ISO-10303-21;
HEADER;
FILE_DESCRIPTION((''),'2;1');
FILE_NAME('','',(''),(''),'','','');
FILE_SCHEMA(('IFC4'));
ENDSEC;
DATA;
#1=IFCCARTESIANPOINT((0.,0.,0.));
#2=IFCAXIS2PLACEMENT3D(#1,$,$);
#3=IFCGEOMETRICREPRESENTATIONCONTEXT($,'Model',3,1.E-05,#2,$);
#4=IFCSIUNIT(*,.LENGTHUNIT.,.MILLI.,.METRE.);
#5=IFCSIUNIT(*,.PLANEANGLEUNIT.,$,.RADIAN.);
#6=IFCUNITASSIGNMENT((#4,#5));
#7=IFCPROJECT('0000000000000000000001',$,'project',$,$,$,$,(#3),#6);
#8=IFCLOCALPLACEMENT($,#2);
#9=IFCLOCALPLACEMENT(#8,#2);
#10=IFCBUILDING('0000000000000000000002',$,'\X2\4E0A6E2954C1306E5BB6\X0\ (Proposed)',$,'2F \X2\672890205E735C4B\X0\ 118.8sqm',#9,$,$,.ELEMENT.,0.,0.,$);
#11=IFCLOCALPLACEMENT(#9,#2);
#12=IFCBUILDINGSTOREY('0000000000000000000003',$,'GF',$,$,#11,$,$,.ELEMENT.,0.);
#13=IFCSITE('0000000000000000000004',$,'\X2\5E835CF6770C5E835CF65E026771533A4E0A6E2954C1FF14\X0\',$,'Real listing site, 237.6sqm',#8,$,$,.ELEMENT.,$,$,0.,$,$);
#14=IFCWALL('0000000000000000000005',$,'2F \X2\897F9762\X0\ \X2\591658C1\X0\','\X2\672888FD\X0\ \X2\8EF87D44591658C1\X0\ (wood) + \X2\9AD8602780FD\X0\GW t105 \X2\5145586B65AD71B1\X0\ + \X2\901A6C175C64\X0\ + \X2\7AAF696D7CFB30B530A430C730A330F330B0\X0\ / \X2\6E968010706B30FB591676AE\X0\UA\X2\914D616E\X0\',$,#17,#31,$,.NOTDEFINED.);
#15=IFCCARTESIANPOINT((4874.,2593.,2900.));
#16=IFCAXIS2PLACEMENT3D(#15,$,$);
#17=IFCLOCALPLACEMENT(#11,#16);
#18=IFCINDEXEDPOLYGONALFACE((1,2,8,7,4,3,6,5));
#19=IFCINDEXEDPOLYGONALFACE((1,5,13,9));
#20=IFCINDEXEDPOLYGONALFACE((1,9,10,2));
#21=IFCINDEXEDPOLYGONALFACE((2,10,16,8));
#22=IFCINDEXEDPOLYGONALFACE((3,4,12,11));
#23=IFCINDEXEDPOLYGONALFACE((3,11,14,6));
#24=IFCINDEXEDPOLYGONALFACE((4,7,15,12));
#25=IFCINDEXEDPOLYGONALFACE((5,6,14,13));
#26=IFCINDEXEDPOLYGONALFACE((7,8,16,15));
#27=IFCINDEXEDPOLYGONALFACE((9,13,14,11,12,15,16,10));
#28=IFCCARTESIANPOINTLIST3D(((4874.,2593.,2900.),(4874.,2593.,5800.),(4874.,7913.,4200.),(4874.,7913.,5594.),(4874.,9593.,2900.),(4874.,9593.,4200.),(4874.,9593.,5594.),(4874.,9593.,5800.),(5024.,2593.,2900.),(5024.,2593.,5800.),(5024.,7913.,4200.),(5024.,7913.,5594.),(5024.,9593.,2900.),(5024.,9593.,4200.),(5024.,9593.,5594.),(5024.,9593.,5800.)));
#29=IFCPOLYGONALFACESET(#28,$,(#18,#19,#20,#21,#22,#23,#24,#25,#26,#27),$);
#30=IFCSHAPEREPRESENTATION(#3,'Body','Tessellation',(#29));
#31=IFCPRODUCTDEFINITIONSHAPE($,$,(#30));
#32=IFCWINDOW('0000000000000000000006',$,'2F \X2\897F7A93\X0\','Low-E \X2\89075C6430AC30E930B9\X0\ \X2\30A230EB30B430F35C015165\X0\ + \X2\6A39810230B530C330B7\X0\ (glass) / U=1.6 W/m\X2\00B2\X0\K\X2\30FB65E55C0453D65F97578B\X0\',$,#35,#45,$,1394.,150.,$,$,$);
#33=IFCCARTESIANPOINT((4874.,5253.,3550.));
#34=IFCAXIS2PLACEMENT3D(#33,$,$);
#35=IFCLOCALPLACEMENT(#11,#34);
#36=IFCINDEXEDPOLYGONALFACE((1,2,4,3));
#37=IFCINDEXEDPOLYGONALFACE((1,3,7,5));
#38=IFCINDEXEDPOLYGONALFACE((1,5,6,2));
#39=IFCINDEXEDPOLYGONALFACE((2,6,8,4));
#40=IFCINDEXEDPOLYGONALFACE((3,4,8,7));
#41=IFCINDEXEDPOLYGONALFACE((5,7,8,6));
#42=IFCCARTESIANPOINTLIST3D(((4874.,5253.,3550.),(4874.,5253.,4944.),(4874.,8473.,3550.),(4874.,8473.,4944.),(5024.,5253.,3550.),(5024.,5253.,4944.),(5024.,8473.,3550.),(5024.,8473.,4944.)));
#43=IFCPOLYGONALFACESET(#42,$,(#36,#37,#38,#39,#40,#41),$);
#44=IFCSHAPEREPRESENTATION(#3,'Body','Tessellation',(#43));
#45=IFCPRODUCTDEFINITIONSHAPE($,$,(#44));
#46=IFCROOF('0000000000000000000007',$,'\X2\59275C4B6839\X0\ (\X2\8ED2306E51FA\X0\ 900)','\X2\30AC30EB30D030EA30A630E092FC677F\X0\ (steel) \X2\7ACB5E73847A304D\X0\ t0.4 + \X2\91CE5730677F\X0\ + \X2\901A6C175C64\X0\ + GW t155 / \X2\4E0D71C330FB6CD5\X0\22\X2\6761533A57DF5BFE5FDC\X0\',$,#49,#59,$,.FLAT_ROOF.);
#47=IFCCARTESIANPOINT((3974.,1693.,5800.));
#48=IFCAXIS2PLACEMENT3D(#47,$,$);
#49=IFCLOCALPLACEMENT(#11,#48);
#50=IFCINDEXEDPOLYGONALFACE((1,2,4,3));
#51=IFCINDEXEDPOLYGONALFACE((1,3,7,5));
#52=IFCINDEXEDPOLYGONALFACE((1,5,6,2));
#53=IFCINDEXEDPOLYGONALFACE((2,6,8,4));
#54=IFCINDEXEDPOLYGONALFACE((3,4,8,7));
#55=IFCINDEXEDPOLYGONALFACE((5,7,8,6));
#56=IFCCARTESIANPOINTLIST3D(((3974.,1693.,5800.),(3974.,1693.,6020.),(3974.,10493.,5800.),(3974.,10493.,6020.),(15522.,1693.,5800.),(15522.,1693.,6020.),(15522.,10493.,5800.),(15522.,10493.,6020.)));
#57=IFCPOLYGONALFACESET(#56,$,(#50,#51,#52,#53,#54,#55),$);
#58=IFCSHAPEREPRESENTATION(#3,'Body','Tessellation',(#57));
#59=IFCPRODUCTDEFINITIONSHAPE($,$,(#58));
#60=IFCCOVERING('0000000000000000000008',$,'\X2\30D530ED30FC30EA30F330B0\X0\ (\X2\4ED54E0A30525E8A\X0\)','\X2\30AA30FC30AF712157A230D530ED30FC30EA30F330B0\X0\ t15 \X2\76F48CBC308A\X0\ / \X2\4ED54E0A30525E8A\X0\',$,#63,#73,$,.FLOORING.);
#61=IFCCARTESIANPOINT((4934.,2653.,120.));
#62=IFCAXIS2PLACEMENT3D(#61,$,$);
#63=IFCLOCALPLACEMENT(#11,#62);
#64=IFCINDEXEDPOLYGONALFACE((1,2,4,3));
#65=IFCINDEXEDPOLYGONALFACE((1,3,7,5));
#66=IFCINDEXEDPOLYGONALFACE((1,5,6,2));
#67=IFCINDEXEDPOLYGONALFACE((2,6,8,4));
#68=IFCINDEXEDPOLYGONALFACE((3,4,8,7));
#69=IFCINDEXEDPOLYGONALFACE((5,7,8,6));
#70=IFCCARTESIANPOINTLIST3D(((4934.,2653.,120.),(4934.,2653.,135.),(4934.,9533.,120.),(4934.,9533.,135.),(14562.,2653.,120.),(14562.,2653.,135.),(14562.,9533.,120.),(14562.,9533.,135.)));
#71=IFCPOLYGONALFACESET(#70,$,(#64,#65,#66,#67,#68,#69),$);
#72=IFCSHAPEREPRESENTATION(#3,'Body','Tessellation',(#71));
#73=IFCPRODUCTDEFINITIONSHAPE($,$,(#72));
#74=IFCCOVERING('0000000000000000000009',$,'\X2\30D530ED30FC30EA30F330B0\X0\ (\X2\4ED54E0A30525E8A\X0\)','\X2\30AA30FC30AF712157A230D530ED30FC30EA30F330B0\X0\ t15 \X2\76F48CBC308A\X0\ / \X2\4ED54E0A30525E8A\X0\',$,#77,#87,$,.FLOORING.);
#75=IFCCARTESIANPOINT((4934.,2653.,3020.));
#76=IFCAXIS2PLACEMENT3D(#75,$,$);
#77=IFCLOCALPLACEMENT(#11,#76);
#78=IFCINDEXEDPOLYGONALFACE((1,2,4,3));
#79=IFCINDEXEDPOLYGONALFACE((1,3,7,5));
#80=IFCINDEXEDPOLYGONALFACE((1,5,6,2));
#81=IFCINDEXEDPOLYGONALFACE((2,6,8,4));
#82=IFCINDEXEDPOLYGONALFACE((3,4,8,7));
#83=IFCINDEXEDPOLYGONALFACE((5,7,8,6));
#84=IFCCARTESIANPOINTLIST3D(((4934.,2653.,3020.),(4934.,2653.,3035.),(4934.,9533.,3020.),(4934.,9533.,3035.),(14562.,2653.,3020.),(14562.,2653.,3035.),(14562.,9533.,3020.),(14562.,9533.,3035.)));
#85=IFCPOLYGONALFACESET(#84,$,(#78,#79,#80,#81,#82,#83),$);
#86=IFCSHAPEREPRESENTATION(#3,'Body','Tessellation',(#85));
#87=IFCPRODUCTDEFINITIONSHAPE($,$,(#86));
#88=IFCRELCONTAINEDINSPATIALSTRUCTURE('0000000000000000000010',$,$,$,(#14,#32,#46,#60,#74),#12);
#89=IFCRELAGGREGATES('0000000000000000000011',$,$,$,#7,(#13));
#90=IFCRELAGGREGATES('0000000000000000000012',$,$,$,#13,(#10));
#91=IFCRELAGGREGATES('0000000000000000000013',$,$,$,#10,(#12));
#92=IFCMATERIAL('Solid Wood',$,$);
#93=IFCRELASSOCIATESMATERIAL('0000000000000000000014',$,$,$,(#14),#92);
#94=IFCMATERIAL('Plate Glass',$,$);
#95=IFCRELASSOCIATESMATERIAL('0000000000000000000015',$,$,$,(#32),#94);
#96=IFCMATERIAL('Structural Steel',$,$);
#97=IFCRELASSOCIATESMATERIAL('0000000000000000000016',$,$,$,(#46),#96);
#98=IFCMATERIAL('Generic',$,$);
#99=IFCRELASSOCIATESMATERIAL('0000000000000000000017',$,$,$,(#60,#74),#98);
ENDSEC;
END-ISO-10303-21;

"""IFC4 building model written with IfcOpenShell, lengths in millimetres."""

from ifc_helpers import new_model, si_unit, frame, frame_2d, origin, place, context, project, spatial, rectangle, extrude, material, element, fill, save


model = new_model("IFC4")

# Units and contexts
model_context = context("Model", 3, precision=1e-05, world=origin())
ifc_project = project(units=[si_unit("LENGTHUNIT", "METRE", prefix="MILLI"), si_unit("PLANEANGLEUNIT", "RADIAN")], contexts=[model_context])

# Site, building, storey
site_placement = place(None, origin())
site = spatial("IfcSite", under=ifc_project, at=site_placement, Name="広島県広島市東区上温品４", ObjectType="Real listing site, 237.6sqm", CompositionType="ELEMENT", RefElevation=0.0)
building_placement = place(site_placement, origin())
building = spatial("IfcBuilding", under=site, at=building_placement, Name="上温品の家 (Proposed)", ObjectType="2F 木造平屋 118.8sqm", CompositionType="ELEMENT", ElevationOfRefHeight=0.0, ElevationOfTerrain=0.0)
storey_placement = place(building_placement, origin())
storey = spatial("IfcBuildingStorey", under=building, at=storey_placement, Name="GF", CompositionType="ELEMENT", Elevation=0.0)

# Shared definitions
ifc_material_1 = material(Name="Solid Wood")

# Shared definitions
ifc_material_2 = material(Name="Plate Glass")

# Wall, opening, window
wall_1_placement = place(storey_placement, frame((4874.0, 2593.0, 2900.0)))
wall_1 = element("IfcWall", 1, at=wall_1_placement, inside=storey, material=ifc_material_1, Name="2F 西面 外壁", Description="木製 軸組外壁 (wood) + 高性能GW t105 充填断熱 + 通気層 + 窯業系サイディング / 準耐火・外皮UA配慮", PredefinedType="NOTDEFINED", context=model_context, shape_type="SweptSolid", body=[
    extrude(rectangle(XDim=150.0, YDim=7000.0, at=frame_2d((75.0, 3500.0))), frame((4874.0, 2593.0, 2900.0)), (0.0, 0.0, 1.0), 2900.0),
])
opening_1_placement = place(storey_placement, frame((4874.0, 5253.0, 3550.0)))
opening_1 = element("IfcOpeningElement", 2, at=opening_1_placement, cuts=wall_1, PredefinedType="NOTDEFINED", context=model_context, shape_type="SweptSolid", body=[
    extrude(rectangle(XDim=150.0, YDim=3220.0, at=frame_2d((75.0, 1610.0))), frame((4874.0, 5253.0, 3550.0)), (0.0, 0.0, 1.0), 1394.0),
])
window_1_placement = place(storey_placement, frame((4874.0, 5253.0, 3550.0)))
window_1 = element("IfcWindow", 3, at=window_1_placement, inside=storey, material=ifc_material_2, Name="2F 西窓", Description="Low-E 複層ガラス アルゴン封入 + 樹脂サッシ (glass) / U=1.6 W/m²K・日射取得型", OverallHeight=1394.0, OverallWidth=150.0, context=model_context, shape_type="SweptSolid", body=[
    extrude(rectangle(XDim=150.0, YDim=3220.0, at=frame_2d((75.0, 1610.0))), frame((4874.0, 5253.0, 3550.0)), (0.0, 0.0, 1.0), 1394.0),
])
fill(opening_1, window_1)

# Roof
ifc_material_3 = material(Name="Structural Steel")
roof_placement = place(storey_placement, frame((3974.0, 1693.0, 5800.0)))
element("IfcRoof", 4, at=roof_placement, inside=storey, material=ifc_material_3, Name="大屋根 (軒の出 900)", Description="ガルバリウム鋼板 (steel) 立平葺き t0.4 + 野地板 + 通気層 + GW t155 / 不燃・法22条区域対応", PredefinedType="FLAT_ROOF", context=model_context, shape_type="SweptSolid", body=[
    extrude(rectangle(XDim=11548.0, YDim=8800.0, at=frame_2d((5774.0, 4400.0))), frame((3974.0, 1693.0, 5800.0)), (0.0, 0.0, 1.0), 220.0),
])

# Coverings
ifc_material_4 = material(Name="Generic")
covering_1_placement = place(storey_placement, frame((4934.0, 2653.0, 120.0)))
element("IfcCovering", 5, at=covering_1_placement, inside=storey, material=ifc_material_4, Name="フローリング (仕上げ床)", Description="オーク無垢フローリング t15 直貼り / 仕上げ床", PredefinedType="FLOORING", context=model_context, shape_type="SweptSolid", body=[
    extrude(rectangle(XDim=9628.0, YDim=6880.0, at=frame_2d((4814.0, 3440.0))), frame((4934.0, 2653.0, 120.0)), (0.0, 0.0, 1.0), 15.0),
])
covering_2_placement = place(storey_placement, frame((4934.0, 2653.0, 3020.0)))
element("IfcCovering", 6, at=covering_2_placement, inside=storey, material=ifc_material_4, Name="フローリング (仕上げ床)", Description="オーク無垢フローリング t15 直貼り / 仕上げ床", PredefinedType="FLOORING", context=model_context, shape_type="SweptSolid", body=[
    extrude(rectangle(XDim=9628.0, YDim=6880.0, at=frame_2d((4814.0, 3440.0))), frame((4934.0, 2653.0, 3020.0)), (0.0, 0.0, 1.0), 15.0),
])

save(model, "model.ifc")
